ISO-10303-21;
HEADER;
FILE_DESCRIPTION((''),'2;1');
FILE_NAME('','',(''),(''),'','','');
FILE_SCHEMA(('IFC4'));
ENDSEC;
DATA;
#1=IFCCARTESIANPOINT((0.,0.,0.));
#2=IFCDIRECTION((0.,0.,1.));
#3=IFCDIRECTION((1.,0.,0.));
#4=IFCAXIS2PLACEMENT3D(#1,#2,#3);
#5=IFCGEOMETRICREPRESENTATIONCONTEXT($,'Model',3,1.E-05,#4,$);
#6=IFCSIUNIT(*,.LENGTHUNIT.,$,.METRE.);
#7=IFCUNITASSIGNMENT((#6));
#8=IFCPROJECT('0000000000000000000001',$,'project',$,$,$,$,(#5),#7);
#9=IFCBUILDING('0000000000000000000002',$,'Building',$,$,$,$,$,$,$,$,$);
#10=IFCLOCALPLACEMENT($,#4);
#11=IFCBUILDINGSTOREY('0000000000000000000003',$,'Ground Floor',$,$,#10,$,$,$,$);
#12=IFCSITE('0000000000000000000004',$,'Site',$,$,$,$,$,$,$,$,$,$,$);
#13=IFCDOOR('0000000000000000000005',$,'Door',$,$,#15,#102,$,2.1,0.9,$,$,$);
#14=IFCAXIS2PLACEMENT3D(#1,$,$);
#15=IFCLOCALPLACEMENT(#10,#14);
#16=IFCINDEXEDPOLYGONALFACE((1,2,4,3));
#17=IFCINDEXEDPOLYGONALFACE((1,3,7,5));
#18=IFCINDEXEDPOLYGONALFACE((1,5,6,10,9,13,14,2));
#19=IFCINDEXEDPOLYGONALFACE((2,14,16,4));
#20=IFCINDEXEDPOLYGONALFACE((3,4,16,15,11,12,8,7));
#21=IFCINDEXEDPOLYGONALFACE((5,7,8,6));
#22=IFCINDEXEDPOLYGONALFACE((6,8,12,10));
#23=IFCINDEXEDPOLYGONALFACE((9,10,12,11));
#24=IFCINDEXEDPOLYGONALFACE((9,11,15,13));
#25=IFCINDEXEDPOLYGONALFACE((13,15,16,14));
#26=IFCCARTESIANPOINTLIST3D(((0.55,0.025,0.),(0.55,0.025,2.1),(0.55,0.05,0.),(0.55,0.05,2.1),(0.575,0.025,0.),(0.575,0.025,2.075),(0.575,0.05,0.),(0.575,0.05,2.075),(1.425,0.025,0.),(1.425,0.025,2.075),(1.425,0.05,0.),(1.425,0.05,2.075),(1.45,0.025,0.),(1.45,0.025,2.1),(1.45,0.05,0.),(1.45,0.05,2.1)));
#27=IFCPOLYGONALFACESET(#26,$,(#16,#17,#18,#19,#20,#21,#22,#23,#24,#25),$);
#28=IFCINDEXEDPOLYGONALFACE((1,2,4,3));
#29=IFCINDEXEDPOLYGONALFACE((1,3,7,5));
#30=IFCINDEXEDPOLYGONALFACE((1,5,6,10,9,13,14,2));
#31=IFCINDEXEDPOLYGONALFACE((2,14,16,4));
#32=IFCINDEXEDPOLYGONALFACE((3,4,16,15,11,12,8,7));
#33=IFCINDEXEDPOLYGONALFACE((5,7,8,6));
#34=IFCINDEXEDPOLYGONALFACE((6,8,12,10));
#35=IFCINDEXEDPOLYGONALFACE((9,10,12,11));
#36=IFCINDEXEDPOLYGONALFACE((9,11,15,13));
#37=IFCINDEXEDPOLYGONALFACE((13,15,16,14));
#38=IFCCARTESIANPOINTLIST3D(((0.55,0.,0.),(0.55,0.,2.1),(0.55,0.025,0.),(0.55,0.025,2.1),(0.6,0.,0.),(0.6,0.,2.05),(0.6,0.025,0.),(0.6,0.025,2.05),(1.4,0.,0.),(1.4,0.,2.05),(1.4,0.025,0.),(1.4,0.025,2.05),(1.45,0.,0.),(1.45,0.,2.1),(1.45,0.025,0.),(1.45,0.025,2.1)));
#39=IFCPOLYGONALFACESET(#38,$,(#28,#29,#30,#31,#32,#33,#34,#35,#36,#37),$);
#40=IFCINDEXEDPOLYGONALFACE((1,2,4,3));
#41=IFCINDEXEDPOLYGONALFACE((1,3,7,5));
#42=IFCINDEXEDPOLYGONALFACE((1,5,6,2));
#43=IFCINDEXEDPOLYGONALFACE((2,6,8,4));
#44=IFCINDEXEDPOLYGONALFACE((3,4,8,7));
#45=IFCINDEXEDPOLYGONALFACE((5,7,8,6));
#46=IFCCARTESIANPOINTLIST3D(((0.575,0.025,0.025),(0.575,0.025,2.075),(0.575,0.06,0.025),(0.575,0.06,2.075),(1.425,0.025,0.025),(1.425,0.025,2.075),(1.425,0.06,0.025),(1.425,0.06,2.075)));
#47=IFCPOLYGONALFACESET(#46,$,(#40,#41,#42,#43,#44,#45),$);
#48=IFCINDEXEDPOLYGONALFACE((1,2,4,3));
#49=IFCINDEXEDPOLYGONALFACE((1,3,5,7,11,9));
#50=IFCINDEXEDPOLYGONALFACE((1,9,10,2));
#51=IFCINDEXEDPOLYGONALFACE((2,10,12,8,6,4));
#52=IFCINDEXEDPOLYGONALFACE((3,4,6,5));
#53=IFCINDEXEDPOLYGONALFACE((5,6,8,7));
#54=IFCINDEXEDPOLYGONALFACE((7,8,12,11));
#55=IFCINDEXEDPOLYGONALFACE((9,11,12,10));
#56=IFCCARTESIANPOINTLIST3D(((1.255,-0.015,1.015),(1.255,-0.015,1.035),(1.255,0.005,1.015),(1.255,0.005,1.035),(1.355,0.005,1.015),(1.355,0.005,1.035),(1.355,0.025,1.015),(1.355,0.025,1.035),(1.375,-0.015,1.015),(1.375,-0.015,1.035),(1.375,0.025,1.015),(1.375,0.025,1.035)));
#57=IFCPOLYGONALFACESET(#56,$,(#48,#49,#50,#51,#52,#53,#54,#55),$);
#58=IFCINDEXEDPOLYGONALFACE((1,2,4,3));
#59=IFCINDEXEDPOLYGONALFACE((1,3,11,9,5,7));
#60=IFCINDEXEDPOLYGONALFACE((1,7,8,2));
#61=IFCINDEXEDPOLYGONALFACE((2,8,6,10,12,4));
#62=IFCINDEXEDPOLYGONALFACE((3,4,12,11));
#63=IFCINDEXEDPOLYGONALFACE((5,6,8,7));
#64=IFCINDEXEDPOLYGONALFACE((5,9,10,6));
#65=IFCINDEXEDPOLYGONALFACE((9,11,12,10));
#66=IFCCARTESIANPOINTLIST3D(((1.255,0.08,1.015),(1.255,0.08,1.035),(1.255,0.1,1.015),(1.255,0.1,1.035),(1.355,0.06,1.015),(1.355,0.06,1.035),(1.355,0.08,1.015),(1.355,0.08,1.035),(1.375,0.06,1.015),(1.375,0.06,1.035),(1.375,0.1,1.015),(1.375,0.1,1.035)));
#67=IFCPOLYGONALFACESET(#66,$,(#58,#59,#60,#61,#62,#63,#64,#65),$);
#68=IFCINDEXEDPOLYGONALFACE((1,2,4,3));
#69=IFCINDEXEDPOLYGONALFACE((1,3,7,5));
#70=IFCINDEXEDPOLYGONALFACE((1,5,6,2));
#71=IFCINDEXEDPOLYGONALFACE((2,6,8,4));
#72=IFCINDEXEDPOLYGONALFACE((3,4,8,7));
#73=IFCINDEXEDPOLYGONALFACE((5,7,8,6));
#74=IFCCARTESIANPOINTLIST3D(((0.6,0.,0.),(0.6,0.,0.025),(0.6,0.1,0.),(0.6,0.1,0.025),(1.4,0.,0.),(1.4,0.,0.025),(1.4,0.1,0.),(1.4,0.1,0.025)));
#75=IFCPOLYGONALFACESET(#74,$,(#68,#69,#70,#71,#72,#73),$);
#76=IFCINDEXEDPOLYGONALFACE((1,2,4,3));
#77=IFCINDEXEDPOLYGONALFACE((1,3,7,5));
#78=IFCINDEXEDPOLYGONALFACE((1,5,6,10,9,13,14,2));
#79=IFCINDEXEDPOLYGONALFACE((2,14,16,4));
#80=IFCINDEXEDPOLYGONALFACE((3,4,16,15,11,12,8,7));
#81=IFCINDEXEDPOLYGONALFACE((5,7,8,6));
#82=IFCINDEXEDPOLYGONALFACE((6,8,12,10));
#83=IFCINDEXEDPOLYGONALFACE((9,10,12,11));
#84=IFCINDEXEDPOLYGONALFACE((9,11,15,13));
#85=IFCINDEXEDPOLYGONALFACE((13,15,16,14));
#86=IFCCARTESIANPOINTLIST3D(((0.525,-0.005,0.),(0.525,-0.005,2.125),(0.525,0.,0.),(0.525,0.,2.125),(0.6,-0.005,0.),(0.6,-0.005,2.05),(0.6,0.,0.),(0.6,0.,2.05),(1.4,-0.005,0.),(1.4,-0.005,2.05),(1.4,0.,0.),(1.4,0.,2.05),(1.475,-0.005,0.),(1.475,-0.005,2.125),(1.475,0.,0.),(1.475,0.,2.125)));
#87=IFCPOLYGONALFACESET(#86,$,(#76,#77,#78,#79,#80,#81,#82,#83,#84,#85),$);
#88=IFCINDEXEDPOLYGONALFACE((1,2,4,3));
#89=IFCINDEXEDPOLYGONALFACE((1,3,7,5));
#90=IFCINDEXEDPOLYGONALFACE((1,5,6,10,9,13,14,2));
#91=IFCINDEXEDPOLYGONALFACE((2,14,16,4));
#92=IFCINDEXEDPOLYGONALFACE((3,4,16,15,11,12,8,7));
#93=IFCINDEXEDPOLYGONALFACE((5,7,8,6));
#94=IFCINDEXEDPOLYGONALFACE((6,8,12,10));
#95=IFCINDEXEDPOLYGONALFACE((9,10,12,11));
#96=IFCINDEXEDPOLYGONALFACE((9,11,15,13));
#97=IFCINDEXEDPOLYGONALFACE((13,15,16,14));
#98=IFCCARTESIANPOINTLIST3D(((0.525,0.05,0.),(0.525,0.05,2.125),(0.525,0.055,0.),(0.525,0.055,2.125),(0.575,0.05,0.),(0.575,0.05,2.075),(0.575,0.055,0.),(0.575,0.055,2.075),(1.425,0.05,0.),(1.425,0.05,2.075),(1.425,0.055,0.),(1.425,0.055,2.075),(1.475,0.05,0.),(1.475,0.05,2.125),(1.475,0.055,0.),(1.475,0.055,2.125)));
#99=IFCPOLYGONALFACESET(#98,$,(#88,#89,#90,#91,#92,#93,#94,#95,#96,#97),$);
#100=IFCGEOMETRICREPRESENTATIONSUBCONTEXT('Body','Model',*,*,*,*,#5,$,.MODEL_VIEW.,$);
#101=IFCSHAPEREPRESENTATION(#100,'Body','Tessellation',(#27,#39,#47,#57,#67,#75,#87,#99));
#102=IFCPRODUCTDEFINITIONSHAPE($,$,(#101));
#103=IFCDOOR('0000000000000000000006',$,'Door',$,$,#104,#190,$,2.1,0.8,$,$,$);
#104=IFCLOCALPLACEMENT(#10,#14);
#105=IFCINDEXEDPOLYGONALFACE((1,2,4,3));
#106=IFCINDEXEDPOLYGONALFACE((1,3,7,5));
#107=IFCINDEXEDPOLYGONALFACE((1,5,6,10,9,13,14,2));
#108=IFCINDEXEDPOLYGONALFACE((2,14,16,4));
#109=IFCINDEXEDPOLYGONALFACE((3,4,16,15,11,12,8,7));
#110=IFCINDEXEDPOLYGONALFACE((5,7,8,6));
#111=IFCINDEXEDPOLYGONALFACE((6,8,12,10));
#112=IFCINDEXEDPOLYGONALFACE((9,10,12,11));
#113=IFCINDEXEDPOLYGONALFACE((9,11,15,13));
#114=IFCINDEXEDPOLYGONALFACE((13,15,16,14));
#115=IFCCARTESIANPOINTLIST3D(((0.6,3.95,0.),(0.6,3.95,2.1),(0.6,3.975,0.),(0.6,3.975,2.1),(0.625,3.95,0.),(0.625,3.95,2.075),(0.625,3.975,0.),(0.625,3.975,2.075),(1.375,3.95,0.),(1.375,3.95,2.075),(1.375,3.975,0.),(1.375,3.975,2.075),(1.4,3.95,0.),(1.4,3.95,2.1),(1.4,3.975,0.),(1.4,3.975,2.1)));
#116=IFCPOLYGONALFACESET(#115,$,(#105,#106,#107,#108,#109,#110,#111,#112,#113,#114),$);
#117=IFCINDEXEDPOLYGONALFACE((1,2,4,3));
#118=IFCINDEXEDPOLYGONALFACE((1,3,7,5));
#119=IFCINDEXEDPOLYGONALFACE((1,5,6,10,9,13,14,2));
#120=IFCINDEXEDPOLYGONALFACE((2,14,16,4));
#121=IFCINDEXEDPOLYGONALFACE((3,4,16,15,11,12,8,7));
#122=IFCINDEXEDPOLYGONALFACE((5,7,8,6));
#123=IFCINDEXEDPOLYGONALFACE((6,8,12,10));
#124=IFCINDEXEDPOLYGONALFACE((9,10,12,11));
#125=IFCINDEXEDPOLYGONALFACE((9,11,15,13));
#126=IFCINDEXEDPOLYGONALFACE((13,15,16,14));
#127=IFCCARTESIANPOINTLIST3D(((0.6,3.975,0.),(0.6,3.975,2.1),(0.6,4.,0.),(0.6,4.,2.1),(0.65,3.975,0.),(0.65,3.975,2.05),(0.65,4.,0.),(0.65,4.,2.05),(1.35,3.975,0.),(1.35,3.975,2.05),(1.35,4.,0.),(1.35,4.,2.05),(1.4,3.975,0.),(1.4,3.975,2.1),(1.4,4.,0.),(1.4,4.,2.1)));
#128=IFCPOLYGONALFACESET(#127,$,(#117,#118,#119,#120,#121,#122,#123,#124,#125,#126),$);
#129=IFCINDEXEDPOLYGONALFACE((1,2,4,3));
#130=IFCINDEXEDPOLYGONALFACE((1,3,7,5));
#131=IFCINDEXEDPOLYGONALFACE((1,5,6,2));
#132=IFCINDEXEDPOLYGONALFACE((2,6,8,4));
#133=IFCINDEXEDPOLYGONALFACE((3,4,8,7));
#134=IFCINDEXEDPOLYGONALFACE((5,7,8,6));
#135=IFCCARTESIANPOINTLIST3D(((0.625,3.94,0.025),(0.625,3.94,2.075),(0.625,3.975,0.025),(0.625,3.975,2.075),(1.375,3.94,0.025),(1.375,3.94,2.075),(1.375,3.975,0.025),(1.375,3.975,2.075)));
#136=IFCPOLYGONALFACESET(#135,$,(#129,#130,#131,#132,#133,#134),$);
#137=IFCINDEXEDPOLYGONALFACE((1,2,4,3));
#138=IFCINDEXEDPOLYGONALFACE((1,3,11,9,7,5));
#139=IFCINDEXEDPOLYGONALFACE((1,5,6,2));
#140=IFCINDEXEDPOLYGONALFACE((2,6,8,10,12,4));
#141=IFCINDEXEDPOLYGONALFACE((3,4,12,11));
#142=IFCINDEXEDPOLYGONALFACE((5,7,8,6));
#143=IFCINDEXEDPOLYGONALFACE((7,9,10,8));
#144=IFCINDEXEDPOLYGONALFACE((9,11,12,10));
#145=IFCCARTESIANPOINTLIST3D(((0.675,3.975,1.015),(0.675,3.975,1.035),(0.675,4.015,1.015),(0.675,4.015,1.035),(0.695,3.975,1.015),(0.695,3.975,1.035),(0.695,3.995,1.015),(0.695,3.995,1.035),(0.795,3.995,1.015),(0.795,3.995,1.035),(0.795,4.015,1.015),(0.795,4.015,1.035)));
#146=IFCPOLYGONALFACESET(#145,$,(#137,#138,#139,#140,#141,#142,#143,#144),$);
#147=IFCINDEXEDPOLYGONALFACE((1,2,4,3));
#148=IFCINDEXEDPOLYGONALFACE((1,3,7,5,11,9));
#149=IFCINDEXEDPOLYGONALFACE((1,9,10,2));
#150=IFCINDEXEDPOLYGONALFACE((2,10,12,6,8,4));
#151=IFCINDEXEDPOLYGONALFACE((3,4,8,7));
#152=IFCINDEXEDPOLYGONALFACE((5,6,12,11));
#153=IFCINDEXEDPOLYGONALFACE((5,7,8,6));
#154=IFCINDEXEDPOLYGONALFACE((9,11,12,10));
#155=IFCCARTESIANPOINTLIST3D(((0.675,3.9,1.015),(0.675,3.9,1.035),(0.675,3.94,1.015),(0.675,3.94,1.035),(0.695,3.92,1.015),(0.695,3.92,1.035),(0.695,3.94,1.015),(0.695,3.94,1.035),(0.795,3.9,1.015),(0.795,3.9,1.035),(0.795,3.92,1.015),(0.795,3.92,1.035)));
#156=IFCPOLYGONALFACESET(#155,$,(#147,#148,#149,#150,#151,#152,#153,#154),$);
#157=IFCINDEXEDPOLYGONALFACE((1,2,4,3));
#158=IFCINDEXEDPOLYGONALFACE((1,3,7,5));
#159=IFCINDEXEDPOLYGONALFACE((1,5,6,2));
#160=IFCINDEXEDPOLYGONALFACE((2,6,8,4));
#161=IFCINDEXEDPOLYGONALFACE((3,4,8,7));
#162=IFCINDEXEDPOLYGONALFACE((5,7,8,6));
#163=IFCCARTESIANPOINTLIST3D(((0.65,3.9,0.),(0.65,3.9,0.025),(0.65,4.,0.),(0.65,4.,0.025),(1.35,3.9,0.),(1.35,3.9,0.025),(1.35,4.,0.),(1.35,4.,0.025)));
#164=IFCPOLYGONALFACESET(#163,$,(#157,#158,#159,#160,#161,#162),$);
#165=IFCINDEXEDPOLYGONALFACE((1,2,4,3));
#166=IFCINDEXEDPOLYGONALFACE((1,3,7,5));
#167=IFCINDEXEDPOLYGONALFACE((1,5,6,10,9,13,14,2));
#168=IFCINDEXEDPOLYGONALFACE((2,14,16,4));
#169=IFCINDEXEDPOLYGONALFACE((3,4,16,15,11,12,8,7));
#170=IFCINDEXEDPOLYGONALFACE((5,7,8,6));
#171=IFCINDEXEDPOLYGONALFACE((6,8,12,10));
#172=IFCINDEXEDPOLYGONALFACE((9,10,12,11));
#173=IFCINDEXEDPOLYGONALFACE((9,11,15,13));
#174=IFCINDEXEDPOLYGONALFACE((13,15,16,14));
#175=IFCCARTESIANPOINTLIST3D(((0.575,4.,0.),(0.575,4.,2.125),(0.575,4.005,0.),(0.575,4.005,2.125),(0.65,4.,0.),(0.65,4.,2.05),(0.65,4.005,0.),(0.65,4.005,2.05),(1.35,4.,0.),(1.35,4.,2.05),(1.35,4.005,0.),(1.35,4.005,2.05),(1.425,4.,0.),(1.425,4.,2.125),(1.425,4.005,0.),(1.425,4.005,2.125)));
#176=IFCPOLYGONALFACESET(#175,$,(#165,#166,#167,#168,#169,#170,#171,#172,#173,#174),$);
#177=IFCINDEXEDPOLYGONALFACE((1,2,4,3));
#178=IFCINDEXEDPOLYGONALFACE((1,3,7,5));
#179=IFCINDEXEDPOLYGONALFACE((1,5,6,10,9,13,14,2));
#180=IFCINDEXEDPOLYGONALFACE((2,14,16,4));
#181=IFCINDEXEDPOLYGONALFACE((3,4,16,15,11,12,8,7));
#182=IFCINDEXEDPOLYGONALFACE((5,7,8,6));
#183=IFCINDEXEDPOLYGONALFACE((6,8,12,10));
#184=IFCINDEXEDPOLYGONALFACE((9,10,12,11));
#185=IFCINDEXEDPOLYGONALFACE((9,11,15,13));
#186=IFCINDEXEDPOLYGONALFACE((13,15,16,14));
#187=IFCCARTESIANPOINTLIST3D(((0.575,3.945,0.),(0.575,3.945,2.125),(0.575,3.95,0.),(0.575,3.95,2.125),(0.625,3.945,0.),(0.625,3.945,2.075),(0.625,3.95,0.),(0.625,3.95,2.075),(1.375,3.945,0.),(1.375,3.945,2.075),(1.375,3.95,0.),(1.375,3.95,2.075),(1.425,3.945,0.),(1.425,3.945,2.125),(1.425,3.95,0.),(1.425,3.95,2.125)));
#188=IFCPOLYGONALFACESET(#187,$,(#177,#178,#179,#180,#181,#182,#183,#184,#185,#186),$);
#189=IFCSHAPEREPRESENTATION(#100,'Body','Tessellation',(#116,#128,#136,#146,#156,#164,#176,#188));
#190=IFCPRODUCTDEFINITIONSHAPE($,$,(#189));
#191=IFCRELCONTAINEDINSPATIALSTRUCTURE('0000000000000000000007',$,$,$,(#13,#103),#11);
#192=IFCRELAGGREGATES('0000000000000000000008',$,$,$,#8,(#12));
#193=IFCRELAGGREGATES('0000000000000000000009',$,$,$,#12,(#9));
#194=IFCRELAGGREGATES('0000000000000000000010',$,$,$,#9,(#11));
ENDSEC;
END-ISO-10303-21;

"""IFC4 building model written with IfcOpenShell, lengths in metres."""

from ifc_helpers import new_model, si_unit, frame, origin_with_axes, place, context, subcontext, project, spatial, line, indexed_curve, outline, extrude, element, save


model = new_model("IFC4")

# Units and contexts
model_context = context("Model", 3, precision=1e-05, world=origin_with_axes())
body_context = subcontext(model_context, "Body", "Model", "MODEL_VIEW")
ifc_project = project(units=[si_unit("LENGTHUNIT", "METRE")], contexts=[model_context])

# Site, building, storey
site = spatial("IfcSite", under=ifc_project, Name="Site")
building = spatial("IfcBuilding", under=site, Name="Building")
storey_placement = place(None, origin_with_axes())
storey = spatial("IfcBuildingStorey", under=building, at=storey_placement, Name="Ground Floor")

# Doors
door_1_placement = place(storey_placement, frame((0.55, 0.0, 0.0), z_axis=(0.0, 0.0, 1.0), x_axis=(1.0, 0.0, 0.0)))
element("IfcDoor", 1, at=door_1_placement, inside=storey, Name="Door", OverallHeight=2.1, OverallWidth=0.9, context=body_context, shape_type="SweptSolid", body=[
    extrude(outline(indexed_curve([(0.0, 0.0), (0.0, 2.1), (0.9, 2.1), (0.9, 0.0), (0.875, 0.0), (0.875, 2.075), (0.025, 2.075), (0.025, 0.0)], segments=[line(1, 2, 3, 4, 5, 6, 7, 8, 1)])), frame((0.0, 0.025, 0.0), z_axis=(0.0, -1.0, 0.0), x_axis=(1.0, 0.0, 0.0)), (0.0, 0.0, -1.0), 0.025),
    extrude(outline(indexed_curve([(0.0, 0.0), (0.0, 2.1), (0.9, 2.1), (0.9, 0.0), (0.85, 0.0), (0.85, 2.05), (0.05, 2.05), (0.05, 0.0)], segments=[line(1, 2, 3, 4, 5, 6, 7, 8, 1)])), frame((0.0, 0.0, 0.0), z_axis=(0.0, -1.0, 0.0), x_axis=(1.0, 0.0, 0.0)), (0.0, 0.0, -1.0), 0.025),
    extrude(outline(indexed_curve([(0.0, 0.0), (0.85, 0.0), (0.85, 0.035), (0.0, 0.035)], segments=[line(1, 2, 3, 4, 1)])), frame((0.025, 0.025, 0.025), z_axis=(0.0, 0.0, 1.0), x_axis=(1.0, 0.0, 0.0)), (0.0, 0.0, 1.0), 2.05),
    extrude(outline(indexed_curve([(0.0, 0.0), (0.0, -0.04), (-0.12, -0.04), (-0.12, -0.02), (-0.02, -0.02), (-0.02, 0.0)], segments=[line(1, 2, 3, 4, 5, 6, 1)])), frame((0.825, 0.025, 1.015), z_axis=(0.0, 0.0, 1.0), x_axis=(1.0, 0.0, 0.0)), (0.0, 0.0, 1.0), 0.02),
    extrude(outline(indexed_curve([(0.0, 0.0), (0.0, 0.04), (-0.12, 0.04), (-0.12, 0.02), (-0.02, 0.02), (-0.02, 0.0)], segments=[line(1, 2, 3, 4, 5, 6, 1)])), frame((0.825, 0.06, 1.015), z_axis=(0.0, 0.0, 1.0), x_axis=(1.0, 0.0, 0.0)), (0.0, 0.0, 1.0), 0.02),
    extrude(outline(indexed_curve([(0.0, 0.0), (0.8, 0.0), (0.8, 0.1), (0.0, 0.1)], segments=[line(1, 2, 3, 4, 1)])), frame((0.05, 0.0, 0.0), z_axis=(0.0, 0.0, 1.0), x_axis=(1.0, 0.0, 0.0)), (0.0, 0.0, 1.0), 0.025),
    extrude(outline(indexed_curve([(0.0, 0.0), (0.0, 2.125), (0.95, 2.125), (0.95, 0.0), (0.875, 0.0), (0.875, 2.05), (0.075, 2.05), (0.075, 0.0)], segments=[line(1, 2, 3, 4, 5, 6, 7, 8, 1)])), frame((-0.025, -0.005, 0.0), z_axis=(0.0, -1.0, 0.0), x_axis=(1.0, 0.0, 0.0)), (0.0, 0.0, -1.0), 0.005),
    extrude(outline(indexed_curve([(0.0, 0.0), (0.0, 2.125), (0.95, 2.125), (0.95, 0.0), (0.9, 0.0), (0.9, 2.075), (0.05, 2.075), (0.05, 0.0)], segments=[line(1, 2, 3, 4, 5, 6, 7, 8, 1)])), frame((-0.025, 0.05, 0.0), z_axis=(0.0, -1.0, 0.0), x_axis=(1.0, 0.0, 0.0)), (0.0, 0.0, -1.0), 0.005),
])
door_2_placement = place(storey_placement, frame((1.4, 4.0, 0.0), z_axis=(0.0, 0.0, 1.0), x_axis=(-1.0, 0.0, 0.0)))
element("IfcDoor", 2, at=door_2_placement, inside=storey, Name="Door", OverallHeight=2.1, OverallWidth=0.8, context=body_context, shape_type="SweptSolid", body=[
    extrude(outline(indexed_curve([(0.0, 0.0), (0.0, 2.1), (0.8, 2.1), (0.8, 0.0), (0.775, 0.0), (0.775, 2.075), (0.025, 2.075), (0.025, 0.0)], segments=[line(1, 2, 3, 4, 5, 6, 7, 8, 1)])), frame((0.0, 0.025, 0.0), z_axis=(0.0, -1.0, 0.0), x_axis=(1.0, 0.0, 0.0)), (0.0, 0.0, -1.0), 0.025),
    extrude(outline(indexed_curve([(0.0, 0.0), (0.0, 2.1), (0.8, 2.1), (0.8, 0.0), (0.75, 0.0), (0.75, 2.05), (0.05, 2.05), (0.05, 0.0)], segments=[line(1, 2, 3, 4, 5, 6, 7, 8, 1)])), frame((0.0, 0.0, 0.0), z_axis=(0.0, -1.0, 0.0), x_axis=(1.0, 0.0, 0.0)), (0.0, 0.0, -1.0), 0.025),
    extrude(outline(indexed_curve([(0.0, 0.0), (0.75, 0.0), (0.75, 0.035), (0.0, 0.035)], segments=[line(1, 2, 3, 4, 1)])), frame((0.025, 0.025, 0.025), z_axis=(0.0, 0.0, 1.0), x_axis=(1.0, 0.0, 0.0)), (0.0, 0.0, 1.0), 2.05),
    extrude(outline(indexed_curve([(0.0, 0.0), (0.0, -0.04), (-0.12, -0.04), (-0.12, -0.02), (-0.02, -0.02), (-0.02, 0.0)], segments=[line(1, 2, 3, 4, 5, 6, 1)])), frame((0.725, 0.025, 1.015), z_axis=(0.0, 0.0, 1.0), x_axis=(1.0, 0.0, 0.0)), (0.0, 0.0, 1.0), 0.02),
    extrude(outline(indexed_curve([(0.0, 0.0), (0.0, 0.04), (-0.12, 0.04), (-0.12, 0.02), (-0.02, 0.02), (-0.02, 0.0)], segments=[line(1, 2, 3, 4, 5, 6, 1)])), frame((0.725, 0.06, 1.015), z_axis=(0.0, 0.0, 1.0), x_axis=(1.0, 0.0, 0.0)), (0.0, 0.0, 1.0), 0.02),
    extrude(outline(indexed_curve([(0.0, 0.0), (0.7, 0.0), (0.7, 0.1), (0.0, 0.1)], segments=[line(1, 2, 3, 4, 1)])), frame((0.05, 0.0, 0.0), z_axis=(0.0, 0.0, 1.0), x_axis=(1.0, 0.0, 0.0)), (0.0, 0.0, 1.0), 0.025),
    extrude(outline(indexed_curve([(0.0, 0.0), (0.0, 2.125), (0.85, 2.125), (0.85, 0.0), (0.775, 0.0), (0.775, 2.05), (0.075, 2.05), (0.075, 0.0)], segments=[line(1, 2, 3, 4, 5, 6, 7, 8, 1)])), frame((-0.025, -0.005, 0.0), z_axis=(0.0, -1.0, 0.0), x_axis=(1.0, 0.0, 0.0)), (0.0, 0.0, -1.0), 0.005),
    extrude(outline(indexed_curve([(0.0, 0.0), (0.0, 2.125), (0.85, 2.125), (0.85, 0.0), (0.8, 0.0), (0.8, 2.075), (0.05, 2.075), (0.05, 0.0)], segments=[line(1, 2, 3, 4, 5, 6, 7, 8, 1)])), frame((-0.025, 0.05, 0.0), z_axis=(0.0, -1.0, 0.0), x_axis=(1.0, 0.0, 0.0)), (0.0, 0.0, -1.0), 0.005),
])

save(model, "model.ifc")
